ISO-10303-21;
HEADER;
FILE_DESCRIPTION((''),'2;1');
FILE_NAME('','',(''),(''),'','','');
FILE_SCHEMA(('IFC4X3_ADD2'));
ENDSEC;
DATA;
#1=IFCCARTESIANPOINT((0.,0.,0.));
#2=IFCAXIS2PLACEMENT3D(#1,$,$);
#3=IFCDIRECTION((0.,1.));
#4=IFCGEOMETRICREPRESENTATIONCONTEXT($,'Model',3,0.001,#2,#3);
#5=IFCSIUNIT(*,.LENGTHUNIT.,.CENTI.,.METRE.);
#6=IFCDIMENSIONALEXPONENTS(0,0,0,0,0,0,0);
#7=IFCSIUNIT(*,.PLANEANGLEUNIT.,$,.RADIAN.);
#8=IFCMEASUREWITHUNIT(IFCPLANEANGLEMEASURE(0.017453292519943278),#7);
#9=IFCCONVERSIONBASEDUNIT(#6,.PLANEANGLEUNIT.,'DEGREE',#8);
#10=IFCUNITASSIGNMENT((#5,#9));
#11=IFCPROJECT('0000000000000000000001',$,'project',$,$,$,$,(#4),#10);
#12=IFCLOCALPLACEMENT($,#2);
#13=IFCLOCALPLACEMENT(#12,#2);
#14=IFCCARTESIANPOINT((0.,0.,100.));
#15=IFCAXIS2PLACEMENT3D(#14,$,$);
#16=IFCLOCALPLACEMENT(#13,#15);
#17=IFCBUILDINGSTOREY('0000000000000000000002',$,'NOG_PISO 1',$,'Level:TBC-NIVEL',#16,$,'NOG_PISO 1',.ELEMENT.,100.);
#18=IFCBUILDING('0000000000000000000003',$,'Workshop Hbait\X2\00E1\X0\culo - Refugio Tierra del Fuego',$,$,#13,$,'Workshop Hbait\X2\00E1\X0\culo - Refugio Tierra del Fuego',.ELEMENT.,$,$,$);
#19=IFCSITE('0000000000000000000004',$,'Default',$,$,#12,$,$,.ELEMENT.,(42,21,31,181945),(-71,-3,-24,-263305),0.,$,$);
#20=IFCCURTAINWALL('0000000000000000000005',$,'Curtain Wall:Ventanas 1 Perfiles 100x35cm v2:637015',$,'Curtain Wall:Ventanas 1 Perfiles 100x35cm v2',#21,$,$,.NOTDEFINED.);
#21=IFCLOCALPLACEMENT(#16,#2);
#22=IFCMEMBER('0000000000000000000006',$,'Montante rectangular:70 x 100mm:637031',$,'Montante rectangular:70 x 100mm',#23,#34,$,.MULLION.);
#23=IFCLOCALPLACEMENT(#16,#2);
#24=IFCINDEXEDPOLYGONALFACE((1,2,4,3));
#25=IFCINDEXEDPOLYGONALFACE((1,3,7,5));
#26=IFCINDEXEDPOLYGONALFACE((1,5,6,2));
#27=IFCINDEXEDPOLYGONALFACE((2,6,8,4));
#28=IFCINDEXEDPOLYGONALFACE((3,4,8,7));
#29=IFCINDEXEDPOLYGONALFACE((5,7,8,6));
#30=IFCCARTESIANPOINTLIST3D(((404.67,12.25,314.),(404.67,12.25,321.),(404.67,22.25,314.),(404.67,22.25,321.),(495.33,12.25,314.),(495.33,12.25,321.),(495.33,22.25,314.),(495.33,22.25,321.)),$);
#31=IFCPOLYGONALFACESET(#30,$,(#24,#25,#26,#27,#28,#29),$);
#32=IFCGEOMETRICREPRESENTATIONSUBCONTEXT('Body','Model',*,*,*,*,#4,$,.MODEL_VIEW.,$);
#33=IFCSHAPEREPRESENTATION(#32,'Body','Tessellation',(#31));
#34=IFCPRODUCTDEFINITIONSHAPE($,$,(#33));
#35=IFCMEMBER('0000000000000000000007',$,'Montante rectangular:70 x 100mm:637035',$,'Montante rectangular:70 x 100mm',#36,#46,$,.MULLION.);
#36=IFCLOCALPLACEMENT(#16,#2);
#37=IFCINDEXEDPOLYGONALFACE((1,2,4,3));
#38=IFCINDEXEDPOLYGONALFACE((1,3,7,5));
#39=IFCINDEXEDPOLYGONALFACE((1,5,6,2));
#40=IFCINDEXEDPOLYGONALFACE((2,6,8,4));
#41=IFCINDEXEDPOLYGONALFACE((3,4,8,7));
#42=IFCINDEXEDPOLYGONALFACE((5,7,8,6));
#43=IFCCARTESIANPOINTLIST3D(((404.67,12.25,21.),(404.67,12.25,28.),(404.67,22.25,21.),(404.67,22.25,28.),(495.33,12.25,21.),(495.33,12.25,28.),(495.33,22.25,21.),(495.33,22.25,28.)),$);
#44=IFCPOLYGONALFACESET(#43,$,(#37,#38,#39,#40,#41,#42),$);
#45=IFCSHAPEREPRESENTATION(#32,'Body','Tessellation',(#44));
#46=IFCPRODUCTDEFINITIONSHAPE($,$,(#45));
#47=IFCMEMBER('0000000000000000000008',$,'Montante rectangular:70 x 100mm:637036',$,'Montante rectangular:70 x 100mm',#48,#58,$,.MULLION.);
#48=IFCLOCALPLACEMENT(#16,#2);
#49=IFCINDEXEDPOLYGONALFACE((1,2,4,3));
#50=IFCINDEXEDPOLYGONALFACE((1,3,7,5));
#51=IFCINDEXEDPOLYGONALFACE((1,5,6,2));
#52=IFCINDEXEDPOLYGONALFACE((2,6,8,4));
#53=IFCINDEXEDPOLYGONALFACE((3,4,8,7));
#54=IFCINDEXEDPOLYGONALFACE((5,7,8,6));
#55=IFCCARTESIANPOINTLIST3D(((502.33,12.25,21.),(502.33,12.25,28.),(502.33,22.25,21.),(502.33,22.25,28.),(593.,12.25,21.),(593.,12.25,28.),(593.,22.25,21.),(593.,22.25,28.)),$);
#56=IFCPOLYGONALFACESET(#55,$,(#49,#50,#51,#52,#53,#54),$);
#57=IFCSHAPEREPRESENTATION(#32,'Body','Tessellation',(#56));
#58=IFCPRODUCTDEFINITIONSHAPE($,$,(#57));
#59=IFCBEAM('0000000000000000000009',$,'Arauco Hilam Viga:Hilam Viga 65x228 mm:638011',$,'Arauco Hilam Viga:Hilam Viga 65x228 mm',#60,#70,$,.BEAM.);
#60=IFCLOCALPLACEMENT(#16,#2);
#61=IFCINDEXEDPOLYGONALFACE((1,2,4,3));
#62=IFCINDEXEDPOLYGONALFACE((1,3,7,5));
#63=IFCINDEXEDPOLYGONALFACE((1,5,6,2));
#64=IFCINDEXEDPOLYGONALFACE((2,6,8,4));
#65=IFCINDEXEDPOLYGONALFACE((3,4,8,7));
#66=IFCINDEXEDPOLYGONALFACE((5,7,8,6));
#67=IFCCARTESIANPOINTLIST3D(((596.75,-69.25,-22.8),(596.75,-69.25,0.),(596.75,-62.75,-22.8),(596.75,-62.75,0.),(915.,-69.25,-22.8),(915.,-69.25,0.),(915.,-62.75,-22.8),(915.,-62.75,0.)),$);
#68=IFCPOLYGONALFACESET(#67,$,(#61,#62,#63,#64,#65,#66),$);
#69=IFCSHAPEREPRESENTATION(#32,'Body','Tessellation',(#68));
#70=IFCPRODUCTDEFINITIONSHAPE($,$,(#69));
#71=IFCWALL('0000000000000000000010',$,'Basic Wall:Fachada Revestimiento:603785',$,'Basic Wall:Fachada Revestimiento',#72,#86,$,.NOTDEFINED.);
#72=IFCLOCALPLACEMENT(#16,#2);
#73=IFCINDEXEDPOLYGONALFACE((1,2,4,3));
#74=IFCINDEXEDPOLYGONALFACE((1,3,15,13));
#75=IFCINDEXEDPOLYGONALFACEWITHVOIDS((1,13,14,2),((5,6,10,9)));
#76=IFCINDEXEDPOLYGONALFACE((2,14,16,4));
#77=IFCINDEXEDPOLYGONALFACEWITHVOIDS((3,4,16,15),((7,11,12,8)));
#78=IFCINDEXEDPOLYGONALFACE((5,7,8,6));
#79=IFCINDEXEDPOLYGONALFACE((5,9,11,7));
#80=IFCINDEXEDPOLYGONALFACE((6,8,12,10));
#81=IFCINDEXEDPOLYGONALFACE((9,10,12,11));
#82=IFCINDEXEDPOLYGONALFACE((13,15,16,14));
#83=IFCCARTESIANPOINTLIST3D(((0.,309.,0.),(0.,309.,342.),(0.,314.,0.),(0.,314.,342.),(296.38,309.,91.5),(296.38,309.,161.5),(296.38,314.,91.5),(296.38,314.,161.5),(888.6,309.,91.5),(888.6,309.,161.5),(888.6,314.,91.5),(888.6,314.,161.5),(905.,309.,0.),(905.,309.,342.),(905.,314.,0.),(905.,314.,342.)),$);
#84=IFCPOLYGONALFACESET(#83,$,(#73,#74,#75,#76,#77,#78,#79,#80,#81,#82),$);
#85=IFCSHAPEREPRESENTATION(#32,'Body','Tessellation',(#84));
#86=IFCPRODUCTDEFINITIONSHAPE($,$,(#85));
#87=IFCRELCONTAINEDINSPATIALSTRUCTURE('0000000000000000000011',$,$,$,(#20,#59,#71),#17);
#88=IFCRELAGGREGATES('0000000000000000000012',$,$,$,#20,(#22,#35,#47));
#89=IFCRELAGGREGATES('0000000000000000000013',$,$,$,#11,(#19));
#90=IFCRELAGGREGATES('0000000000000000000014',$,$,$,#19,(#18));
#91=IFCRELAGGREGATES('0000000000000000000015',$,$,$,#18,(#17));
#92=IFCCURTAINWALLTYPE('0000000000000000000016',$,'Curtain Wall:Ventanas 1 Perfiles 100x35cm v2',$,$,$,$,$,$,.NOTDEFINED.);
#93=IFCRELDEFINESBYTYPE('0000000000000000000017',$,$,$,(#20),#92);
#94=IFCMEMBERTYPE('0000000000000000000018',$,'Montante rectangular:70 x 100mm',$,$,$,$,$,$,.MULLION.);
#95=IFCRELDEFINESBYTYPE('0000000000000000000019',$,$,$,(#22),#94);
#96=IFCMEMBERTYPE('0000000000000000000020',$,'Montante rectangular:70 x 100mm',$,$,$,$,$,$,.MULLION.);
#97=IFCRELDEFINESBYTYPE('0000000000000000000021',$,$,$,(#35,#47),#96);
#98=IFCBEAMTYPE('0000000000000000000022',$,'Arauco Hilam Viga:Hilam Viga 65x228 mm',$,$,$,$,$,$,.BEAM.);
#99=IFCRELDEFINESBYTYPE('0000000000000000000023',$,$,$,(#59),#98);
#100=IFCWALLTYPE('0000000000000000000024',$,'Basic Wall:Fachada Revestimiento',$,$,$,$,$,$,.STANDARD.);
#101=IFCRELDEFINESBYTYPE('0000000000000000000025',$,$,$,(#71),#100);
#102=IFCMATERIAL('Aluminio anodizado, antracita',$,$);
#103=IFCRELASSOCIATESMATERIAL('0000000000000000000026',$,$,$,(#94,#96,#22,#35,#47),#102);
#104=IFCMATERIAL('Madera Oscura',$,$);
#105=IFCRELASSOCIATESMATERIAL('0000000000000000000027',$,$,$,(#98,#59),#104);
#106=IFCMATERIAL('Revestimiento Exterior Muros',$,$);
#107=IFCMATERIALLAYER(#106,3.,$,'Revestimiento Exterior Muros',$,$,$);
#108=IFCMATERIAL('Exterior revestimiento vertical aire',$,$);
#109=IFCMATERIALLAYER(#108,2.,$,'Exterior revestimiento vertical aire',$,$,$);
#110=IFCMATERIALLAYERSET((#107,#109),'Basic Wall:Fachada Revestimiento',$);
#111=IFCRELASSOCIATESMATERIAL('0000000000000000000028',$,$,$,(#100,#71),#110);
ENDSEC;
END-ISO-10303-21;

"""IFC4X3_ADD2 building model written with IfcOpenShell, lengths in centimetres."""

from ifc_helpers import new_model, entity, si_unit, converted_unit, direction, frame, frame_2d, origin, origin_2d_with_axis, place, context, subcontext, project, spatial, rectangle, extrude, source, transform, mapped, material, layer, layer_set, material_profile, profile_set, profile_usage, type_object, type_shapes, element, aggregate, save


model = new_model("IFC4X3_ADD2")

# Units and contexts
model_context = context("Model", 3, precision=0.001, world=origin(), true_north=direction((0.0, 1.0)))
body_context = subcontext(model_context, "Body", "Model", "MODEL_VIEW")
ifc_project = project(units=[si_unit("LENGTHUNIT", "METRE", prefix="CENTI"), converted_unit("PLANEANGLEUNIT", "DEGREE", entity("IfcPlaneAngleMeasure", 0.017453292519943278), si_unit("PLANEANGLEUNIT", "RADIAN"), dimensions=[0, 0, 0, 0, 0, 0, 0])], contexts=[model_context])

# Site, building, storey
site_placement = place(None, origin())
site = spatial("IfcSite", under=ifc_project, at=site_placement, Name="Default", CompositionType="ELEMENT", RefLatitude=(42, 21, 31, 181945), RefLongitude=(-71, -3, -24, -263305), RefElevation=0.0)
building_placement = place(site_placement, origin())
building = spatial("IfcBuilding", under=site, at=building_placement, Name="Workshop Hbaitáculo - Refugio Tierra del Fuego", LongName="Workshop Hbaitáculo - Refugio Tierra del Fuego", CompositionType="ELEMENT")
storey_placement = place(building_placement, frame((0.0, 0.0, 100.0)))
storey = spatial("IfcBuildingStorey", under=building, at=storey_placement, Name="NOG_PISO 1", ObjectType="Level:TBC-NIVEL", LongName="NOG_PISO 1", CompositionType="ELEMENT", Elevation=100.0)

# Shared definitions
ifc_material_1 = material(Name="Madera Oscura")
ifc_material_profile_1 = material_profile(ifc_material_1, rectangle(XDim=930.0, YDim=6.5, at=origin_2d_with_axis()), Name="Hilam Viga 65x228 mm")
ifc_profile_set_1 = profile_set([ifc_material_profile_1], Name="Hilam Viga 65x228 mm")
ifc_profile_usage_1 = profile_usage(ifc_profile_set_1, cardinal=8)

# Curtain wall
curtain_wall_type = type_object("IfcCurtainWallType", Name="Curtain Wall:Ventanas 1 Perfiles 100x35cm v2", PredefinedType="NOTDEFINED")
curtain_wall_1_placement = place(storey_placement, frame((0.0, 0.0, -100.0)))
curtain_wall_1 = element("IfcCurtainWall", 1, at=curtain_wall_1_placement, inside=storey, type_object=curtain_wall_type, Name="Curtain Wall:Ventanas 1 Perfiles 100x35cm v2:637015", ObjectType="Curtain Wall:Ventanas 1 Perfiles 100x35cm v2", PredefinedType="NOTDEFINED")
ifc_material_2 = material(Name="Aluminio anodizado, antracita")
ifc_material_profile_2 = material_profile(ifc_material_2, rectangle(XDim=7.0, YDim=10.0, at=origin_2d_with_axis()), Name="70 x 100mm")
ifc_profile_set_2 = profile_set([ifc_material_profile_2], Name="70 x 100mm")
ifc_profile_usage_2 = profile_usage(ifc_profile_set_2)

# Members
member_type_1 = type_object("IfcMemberType", Name="Montante rectangular:70 x 100mm", PredefinedType="MULLION", material=ifc_profile_set_2)
shared_shape_1 = source(origin(), body_context, "Body", "SweptSolid", [
    extrude(rectangle(XDim=7.0, YDim=10.0, at=origin_2d_with_axis()), frame((-3.5, 0.0, -90.67), z_axis=(0.0, 0.0, 1.0), x_axis=(-1.0, 0.0, 0.0)), (0.0, 0.0, 1.0), 90.67),
])
type_shapes(member_type_1, [shared_shape_1])
member_1_placement = place(curtain_wall_1_placement, frame((495.33, 17.25, 421.0), z_axis=(1.0, 0.0, 0.0), x_axis=(0.0, 0.0, 1.0)))
member_1 = element("IfcMember", 2, at=member_1_placement, type_object=member_type_1, material=ifc_profile_usage_2, Name="Montante rectangular:70 x 100mm:637031", ObjectType="Montante rectangular:70 x 100mm", PredefinedType="MULLION", context=body_context, shape_type="MappedRepresentation", body=[
    mapped(shared_shape_1, transform((0.0, 0.0, 0.0), scale=1.0)),
])
member_type_2 = type_object("IfcMemberType", Name="Montante rectangular:70 x 100mm", PredefinedType="MULLION", material=ifc_profile_set_2)
shared_shape_2 = source(origin(), body_context, "Body", "SweptSolid", [
    extrude(rectangle(XDim=7.0, YDim=10.0, at=origin_2d_with_axis()), frame((-3.5, 0.0, -90.67), z_axis=(0.0, 0.0, 1.0), x_axis=(-1.0, 0.0, 0.0)), (0.0, 0.0, 1.0), 90.67),
])
type_shapes(member_type_2, [shared_shape_2])
member_2_placement = place(curtain_wall_1_placement, frame((404.67, 17.25, 121.0), z_axis=(-1.0, 0.0, 0.0), x_axis=(0.0, 0.0, -1.0)))
member_2 = element("IfcMember", 3, at=member_2_placement, type_object=member_type_2, material=ifc_profile_usage_2, Name="Montante rectangular:70 x 100mm:637035", ObjectType="Montante rectangular:70 x 100mm", PredefinedType="MULLION", context=body_context, shape_type="MappedRepresentation", body=[
    mapped(shared_shape_2, transform((0.0, 0.0, 0.0), scale=1.0)),
])
member_3_placement = place(curtain_wall_1_placement, frame((502.33, 17.25, 121.0), z_axis=(-1.0, 0.0, 0.0), x_axis=(0.0, 0.0, -1.0)))
member_3 = element("IfcMember", 4, at=member_3_placement, type_object=member_type_2, material=ifc_profile_usage_2, Name="Montante rectangular:70 x 100mm:637036", ObjectType="Montante rectangular:70 x 100mm", PredefinedType="MULLION", context=body_context, shape_type="MappedRepresentation", body=[
    mapped(shared_shape_2, transform((0.0, 0.0, 0.0), scale=1.0)),
])

# Beam
beam_type_1 = type_object("IfcBeamType", Name="Arauco Hilam Viga:Hilam Viga 65x228 mm", PredefinedType="BEAM", material=ifc_profile_set_1)
shared_shape_3 = source(origin(), body_context, "Body", "SweptSolid", [
    extrude(rectangle(XDim=318.25, YDim=6.5, at=origin_2d_with_axis()), frame((0.0, 0.0, -11.4), z_axis=(0.0, 0.0, 1.0), x_axis=(-1.0, 0.0, 0.0)), (0.0, 0.0, 1.0), 22.8),
])
type_shapes(beam_type_1, [shared_shape_3])
beam_1_placement = place(storey_placement, frame((755.88, -66.0, -11.4)))
element("IfcBeam", 5, at=beam_1_placement, inside=storey, type_object=beam_type_1, material=ifc_profile_usage_1, Name="Arauco Hilam Viga:Hilam Viga 65x228 mm:638011", ObjectType="Arauco Hilam Viga:Hilam Viga 65x228 mm", PredefinedType="BEAM", context=body_context, shape_type="MappedRepresentation", body=[
    mapped(shared_shape_3, transform((0.0, 0.0, 0.0), scale=1.0)),
])

aggregate(curtain_wall_1, [member_1, member_2, member_3])

# Wall, opening
ifc_material_3 = material(Name="Revestimiento Exterior Muros")
ifc_layer_1 = layer(ifc_material_3, 3.0, Name="Revestimiento Exterior Muros")
ifc_material_4 = material(Name="Exterior revestimiento vertical aire")
ifc_layer_2 = layer(ifc_material_4, 2.0, Name="Exterior revestimiento vertical aire")
ifc_layer_set = layer_set([ifc_layer_1, ifc_layer_2], Name="Basic Wall:Fachada Revestimiento")
wall_type = type_object("IfcWallType", Name="Basic Wall:Fachada Revestimiento", PredefinedType="STANDARD", material=ifc_layer_set)
wall_placement = place(storey_placement, frame((905.0, 311.5, 0.0), z_axis=(0.0, 0.0, 1.0), x_axis=(-1.0, 0.0, 0.0)))
wall = element("IfcWall", 6, at=wall_placement, inside=storey, type_object=wall_type, material=ifc_layer_set, Name="Basic Wall:Fachada Revestimiento:603785", ObjectType="Basic Wall:Fachada Revestimiento", PredefinedType="NOTDEFINED", context=body_context, shape_type="SweptSolid", body=[
    extrude(rectangle(XDim=905.0, YDim=5.0, at=frame_2d((452.5, 0.0), x_axis=(-1.0, 0.0))), origin(), (0.0, 0.0, 1.0), 342.0),
])
opening_placement = place(wall_placement, origin())
element("IfcOpeningElement", 7, at=opening_placement, cuts=wall, PredefinedType="OPENING", context=body_context, shape_type="SweptSolid", body=[
    extrude(rectangle(XDim=70.0, YDim=592.22, at=frame_2d((0.0, 0.0), x_axis=(1.0, 0.0))), frame((312.51, 2.5, 126.5), z_axis=(0.0, -1.0, 0.0), x_axis=(0.0, 0.0, -1.0)), (0.0, 0.0, 1.0), 5.0),
])

save(model, "model.ifc")
